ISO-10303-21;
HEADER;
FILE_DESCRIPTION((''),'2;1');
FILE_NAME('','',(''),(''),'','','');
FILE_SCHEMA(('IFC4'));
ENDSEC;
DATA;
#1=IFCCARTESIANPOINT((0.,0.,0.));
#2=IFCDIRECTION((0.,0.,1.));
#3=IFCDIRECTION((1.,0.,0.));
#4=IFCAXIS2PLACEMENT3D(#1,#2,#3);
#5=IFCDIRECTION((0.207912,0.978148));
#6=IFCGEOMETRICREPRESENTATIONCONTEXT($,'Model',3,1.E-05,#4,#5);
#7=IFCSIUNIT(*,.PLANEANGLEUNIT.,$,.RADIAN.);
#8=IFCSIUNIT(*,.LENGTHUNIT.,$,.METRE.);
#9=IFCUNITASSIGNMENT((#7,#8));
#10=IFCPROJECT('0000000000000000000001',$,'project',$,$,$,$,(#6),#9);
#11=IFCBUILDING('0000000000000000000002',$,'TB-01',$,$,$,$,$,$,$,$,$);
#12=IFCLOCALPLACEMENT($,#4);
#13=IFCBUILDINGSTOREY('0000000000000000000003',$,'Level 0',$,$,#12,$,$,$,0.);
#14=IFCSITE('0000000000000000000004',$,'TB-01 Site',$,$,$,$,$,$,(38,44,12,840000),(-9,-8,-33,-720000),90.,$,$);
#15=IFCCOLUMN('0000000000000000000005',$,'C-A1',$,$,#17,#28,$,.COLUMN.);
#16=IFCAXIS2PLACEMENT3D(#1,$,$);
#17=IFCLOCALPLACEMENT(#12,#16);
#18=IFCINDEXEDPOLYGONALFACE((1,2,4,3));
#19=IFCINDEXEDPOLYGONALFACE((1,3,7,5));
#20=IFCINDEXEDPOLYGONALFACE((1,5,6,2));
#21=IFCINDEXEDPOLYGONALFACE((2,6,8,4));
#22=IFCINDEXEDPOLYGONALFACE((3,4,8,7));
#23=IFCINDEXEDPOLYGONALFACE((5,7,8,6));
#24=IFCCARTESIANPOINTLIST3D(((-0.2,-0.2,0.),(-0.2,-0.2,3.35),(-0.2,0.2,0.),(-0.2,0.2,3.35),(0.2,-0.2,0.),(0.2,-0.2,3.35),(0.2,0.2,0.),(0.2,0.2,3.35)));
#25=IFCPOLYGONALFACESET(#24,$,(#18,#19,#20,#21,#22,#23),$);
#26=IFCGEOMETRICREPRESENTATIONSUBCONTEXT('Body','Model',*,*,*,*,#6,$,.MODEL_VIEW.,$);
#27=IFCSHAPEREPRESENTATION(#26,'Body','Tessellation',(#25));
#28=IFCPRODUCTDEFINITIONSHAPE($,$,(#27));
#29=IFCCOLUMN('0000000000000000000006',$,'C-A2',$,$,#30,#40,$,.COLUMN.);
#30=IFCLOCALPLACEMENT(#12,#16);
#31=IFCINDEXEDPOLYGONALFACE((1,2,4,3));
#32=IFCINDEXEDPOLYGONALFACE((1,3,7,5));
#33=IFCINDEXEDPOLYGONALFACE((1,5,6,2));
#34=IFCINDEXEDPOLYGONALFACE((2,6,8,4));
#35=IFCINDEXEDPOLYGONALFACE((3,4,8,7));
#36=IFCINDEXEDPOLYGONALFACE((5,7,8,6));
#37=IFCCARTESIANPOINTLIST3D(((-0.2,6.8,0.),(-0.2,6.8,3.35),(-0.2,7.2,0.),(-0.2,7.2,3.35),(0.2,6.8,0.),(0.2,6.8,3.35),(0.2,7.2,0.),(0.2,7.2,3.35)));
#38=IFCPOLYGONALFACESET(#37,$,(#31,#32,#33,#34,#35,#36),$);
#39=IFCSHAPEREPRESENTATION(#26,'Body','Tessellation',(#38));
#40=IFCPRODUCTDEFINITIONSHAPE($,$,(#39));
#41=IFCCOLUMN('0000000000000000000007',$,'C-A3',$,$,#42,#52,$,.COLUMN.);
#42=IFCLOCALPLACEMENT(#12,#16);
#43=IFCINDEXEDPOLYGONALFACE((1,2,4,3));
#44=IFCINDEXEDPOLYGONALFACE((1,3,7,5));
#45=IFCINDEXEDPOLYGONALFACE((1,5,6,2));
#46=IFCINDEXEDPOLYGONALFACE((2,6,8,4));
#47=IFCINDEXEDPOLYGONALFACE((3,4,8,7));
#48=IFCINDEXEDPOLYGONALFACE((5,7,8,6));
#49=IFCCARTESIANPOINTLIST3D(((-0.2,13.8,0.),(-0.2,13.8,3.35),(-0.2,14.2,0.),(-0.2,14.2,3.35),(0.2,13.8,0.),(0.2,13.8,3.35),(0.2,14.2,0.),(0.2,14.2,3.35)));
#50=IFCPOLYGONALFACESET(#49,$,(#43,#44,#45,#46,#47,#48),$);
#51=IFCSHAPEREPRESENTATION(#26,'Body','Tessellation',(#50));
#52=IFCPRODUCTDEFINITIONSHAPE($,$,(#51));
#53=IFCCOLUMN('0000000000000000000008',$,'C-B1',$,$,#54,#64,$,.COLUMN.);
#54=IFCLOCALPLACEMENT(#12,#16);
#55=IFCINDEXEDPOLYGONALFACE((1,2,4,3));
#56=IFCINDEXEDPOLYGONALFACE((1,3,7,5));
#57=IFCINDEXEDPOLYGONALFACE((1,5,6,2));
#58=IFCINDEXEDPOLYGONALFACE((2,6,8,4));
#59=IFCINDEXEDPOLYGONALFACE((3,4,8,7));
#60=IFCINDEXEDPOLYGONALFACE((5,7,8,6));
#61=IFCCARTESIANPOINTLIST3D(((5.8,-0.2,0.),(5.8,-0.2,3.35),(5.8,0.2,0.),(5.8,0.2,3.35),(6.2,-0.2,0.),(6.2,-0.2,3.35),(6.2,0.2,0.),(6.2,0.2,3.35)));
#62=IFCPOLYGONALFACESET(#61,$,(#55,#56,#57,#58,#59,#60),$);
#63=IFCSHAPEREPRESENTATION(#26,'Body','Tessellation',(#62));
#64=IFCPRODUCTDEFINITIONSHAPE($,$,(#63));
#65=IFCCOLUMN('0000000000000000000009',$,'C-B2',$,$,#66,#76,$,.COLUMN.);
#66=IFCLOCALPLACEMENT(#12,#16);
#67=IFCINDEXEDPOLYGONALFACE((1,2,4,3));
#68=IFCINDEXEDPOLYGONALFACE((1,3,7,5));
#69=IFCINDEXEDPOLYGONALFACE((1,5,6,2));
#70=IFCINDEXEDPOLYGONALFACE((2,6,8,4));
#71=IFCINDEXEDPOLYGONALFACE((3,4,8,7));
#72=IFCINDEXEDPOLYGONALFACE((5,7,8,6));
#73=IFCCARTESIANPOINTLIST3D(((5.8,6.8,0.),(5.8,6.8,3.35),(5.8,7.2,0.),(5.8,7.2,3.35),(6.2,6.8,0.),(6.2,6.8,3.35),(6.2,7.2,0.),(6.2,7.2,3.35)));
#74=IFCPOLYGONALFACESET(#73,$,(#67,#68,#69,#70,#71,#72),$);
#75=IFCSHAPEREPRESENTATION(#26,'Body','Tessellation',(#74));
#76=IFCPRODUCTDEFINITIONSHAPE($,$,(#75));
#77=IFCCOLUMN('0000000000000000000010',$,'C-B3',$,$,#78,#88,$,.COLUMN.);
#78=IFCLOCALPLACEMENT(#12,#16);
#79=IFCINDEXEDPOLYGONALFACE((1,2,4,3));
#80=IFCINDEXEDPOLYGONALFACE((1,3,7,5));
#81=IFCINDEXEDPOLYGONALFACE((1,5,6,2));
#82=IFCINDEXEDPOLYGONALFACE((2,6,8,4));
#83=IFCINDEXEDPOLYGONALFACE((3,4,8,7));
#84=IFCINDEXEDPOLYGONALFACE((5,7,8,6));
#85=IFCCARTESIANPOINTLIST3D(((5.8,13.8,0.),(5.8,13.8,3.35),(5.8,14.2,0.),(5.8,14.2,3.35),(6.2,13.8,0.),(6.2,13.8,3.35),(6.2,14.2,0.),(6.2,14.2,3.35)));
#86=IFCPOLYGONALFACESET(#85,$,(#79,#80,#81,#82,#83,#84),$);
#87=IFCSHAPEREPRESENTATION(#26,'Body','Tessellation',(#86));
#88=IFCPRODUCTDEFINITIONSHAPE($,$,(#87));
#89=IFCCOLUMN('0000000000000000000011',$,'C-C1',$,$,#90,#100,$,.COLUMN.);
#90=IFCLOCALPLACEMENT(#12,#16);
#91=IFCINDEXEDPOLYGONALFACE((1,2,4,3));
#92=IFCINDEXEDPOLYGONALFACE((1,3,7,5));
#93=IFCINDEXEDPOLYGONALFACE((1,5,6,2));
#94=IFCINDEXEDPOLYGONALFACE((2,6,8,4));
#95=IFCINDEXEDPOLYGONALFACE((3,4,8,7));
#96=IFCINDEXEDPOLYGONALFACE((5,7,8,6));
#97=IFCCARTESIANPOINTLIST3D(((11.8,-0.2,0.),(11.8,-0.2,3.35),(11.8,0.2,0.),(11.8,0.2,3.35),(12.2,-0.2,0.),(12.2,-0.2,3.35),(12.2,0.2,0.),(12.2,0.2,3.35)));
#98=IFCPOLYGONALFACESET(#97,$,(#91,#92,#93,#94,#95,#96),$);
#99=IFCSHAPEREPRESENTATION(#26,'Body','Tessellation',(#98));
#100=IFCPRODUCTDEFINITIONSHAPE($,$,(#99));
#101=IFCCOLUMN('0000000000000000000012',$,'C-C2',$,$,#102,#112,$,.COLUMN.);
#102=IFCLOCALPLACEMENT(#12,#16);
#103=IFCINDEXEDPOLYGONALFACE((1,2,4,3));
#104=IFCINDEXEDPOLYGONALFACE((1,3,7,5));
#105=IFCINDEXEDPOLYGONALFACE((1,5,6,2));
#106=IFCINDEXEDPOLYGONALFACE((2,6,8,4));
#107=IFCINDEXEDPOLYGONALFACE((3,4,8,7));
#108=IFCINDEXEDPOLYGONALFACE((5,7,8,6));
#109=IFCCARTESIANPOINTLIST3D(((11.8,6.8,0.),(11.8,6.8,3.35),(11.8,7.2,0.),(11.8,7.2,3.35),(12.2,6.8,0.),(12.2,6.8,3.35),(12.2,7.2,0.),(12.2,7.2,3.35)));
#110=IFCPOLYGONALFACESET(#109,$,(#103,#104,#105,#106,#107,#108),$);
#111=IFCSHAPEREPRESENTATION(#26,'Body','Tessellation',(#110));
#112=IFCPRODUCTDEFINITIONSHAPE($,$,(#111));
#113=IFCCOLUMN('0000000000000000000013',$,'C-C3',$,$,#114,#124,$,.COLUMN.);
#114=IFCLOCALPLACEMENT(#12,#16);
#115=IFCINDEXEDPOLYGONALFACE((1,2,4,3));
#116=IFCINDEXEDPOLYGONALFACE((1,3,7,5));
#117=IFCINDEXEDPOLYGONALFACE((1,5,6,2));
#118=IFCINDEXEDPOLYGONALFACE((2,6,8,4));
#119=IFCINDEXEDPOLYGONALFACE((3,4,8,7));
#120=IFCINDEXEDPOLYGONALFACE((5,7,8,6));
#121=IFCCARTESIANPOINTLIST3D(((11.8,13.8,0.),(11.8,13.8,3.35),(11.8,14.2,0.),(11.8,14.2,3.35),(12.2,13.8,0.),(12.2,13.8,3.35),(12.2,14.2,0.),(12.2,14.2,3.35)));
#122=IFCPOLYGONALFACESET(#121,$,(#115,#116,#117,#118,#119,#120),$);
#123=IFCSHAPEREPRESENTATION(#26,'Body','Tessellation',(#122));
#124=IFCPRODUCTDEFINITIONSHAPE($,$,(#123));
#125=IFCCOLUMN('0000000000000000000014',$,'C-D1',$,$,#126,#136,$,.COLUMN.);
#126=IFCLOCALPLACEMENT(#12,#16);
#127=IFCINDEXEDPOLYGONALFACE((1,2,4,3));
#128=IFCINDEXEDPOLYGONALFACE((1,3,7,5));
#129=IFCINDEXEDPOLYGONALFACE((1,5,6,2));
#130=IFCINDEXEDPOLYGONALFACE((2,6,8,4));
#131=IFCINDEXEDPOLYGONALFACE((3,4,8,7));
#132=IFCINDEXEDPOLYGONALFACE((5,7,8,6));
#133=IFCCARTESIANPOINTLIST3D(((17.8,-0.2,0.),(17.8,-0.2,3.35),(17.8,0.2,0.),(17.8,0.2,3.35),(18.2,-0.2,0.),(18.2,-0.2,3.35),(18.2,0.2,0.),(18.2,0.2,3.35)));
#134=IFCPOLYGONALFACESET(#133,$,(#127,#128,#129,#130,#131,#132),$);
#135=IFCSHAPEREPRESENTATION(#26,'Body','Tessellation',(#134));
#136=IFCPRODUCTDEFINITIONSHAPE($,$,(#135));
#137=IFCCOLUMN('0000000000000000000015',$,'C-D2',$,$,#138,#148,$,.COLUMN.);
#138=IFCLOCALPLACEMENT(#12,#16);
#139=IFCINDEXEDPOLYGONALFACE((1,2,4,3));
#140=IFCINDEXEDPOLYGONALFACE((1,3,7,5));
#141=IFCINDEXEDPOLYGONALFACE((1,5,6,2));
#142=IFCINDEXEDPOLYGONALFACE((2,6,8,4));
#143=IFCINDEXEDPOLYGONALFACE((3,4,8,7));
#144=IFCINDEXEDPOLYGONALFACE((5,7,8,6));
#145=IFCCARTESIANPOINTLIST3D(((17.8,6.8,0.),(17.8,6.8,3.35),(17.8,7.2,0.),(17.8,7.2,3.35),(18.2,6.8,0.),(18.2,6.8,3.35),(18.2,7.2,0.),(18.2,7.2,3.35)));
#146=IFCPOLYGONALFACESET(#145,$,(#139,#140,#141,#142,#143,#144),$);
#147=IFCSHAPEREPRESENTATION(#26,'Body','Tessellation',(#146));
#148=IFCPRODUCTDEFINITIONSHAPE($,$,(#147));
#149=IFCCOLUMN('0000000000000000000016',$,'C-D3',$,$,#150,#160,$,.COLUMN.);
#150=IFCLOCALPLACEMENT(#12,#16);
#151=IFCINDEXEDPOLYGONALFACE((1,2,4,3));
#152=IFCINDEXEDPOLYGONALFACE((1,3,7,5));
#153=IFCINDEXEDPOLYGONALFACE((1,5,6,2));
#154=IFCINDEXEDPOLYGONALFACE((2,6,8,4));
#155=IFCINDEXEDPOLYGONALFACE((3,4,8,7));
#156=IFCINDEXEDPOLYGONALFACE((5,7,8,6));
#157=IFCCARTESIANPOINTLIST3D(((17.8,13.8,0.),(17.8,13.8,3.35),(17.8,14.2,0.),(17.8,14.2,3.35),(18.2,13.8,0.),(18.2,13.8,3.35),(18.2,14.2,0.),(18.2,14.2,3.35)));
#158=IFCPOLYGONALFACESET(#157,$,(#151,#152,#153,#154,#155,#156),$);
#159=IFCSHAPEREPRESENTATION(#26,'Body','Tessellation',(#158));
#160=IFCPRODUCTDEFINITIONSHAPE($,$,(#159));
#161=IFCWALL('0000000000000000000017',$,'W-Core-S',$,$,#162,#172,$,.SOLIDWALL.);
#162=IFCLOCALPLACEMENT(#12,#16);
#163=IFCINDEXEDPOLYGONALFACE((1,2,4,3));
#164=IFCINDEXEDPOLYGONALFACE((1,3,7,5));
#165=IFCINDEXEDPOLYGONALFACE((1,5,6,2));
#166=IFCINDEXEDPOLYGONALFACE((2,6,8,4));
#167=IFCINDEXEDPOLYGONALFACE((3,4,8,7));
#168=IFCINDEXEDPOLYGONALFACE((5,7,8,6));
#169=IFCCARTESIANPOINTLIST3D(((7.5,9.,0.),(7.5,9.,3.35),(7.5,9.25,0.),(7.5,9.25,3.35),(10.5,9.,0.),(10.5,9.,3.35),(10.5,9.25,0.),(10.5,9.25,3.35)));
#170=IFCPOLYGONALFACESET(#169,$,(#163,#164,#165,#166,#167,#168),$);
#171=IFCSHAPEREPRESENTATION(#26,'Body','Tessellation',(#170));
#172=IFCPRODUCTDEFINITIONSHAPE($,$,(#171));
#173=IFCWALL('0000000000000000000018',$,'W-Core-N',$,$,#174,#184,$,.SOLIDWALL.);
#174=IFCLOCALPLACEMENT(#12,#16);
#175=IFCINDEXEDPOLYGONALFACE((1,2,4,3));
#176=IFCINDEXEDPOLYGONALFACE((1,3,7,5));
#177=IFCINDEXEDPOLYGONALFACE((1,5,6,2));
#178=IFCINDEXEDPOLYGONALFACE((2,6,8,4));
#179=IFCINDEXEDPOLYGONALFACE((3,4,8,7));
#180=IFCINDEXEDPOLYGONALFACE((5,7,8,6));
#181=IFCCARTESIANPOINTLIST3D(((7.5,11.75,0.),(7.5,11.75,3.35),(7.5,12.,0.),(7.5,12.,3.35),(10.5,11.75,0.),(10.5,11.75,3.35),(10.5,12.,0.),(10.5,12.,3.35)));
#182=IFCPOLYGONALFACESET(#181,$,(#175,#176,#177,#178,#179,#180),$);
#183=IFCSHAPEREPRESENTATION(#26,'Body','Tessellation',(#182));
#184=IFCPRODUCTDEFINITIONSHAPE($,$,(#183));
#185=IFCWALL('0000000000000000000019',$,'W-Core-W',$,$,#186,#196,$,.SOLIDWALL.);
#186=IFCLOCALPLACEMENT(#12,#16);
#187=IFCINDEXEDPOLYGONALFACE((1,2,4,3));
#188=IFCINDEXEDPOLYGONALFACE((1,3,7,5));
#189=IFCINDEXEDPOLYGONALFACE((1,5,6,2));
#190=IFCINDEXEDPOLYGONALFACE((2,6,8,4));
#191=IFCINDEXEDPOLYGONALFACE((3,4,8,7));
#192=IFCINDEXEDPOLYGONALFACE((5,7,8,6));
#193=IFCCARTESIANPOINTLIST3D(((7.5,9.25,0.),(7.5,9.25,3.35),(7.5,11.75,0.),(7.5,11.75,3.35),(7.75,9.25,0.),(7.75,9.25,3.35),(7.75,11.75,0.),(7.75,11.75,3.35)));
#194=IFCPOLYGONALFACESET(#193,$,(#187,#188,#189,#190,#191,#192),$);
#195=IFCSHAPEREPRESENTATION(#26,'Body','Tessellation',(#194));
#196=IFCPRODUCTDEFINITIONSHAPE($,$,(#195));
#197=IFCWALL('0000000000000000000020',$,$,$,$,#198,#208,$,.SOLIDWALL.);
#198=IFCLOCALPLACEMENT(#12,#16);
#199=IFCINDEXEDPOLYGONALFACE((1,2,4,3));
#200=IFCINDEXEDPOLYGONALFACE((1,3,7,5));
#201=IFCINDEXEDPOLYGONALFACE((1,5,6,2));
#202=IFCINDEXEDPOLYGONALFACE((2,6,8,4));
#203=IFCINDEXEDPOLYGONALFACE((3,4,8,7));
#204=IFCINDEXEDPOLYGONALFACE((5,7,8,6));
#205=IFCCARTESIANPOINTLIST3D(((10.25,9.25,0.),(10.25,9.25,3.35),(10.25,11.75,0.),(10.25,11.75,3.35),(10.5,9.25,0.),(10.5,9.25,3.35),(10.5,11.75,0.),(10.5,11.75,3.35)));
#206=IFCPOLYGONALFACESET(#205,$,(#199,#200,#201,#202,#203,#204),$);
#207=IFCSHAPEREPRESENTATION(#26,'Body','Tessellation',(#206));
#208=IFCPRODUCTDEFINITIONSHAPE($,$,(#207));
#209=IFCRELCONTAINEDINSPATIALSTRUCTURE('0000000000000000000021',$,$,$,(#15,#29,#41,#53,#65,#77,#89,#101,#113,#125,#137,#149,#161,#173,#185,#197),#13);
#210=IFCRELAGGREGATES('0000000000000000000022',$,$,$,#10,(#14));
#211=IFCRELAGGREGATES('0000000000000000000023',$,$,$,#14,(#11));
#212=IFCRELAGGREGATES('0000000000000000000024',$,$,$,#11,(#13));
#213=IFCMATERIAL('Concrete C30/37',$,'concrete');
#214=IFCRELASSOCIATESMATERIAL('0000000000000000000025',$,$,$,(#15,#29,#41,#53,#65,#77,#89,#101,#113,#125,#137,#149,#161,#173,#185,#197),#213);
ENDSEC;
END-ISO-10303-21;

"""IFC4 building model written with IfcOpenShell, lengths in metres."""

from ifc_helpers import new_model, si_unit, direction, frame, origin_with_axes, place, context, subcontext, project, spatial, rectangle, extrude, material, element, save


model = new_model("IFC4")

# Units and contexts
model_context = context("Model", 3, precision=1e-05, world=origin_with_axes(), true_north=direction((0.207912, 0.978148)))
body_context = subcontext(model_context, "Body", "Model", "MODEL_VIEW")
ifc_project = project(units=[si_unit("PLANEANGLEUNIT", "RADIAN"), si_unit("LENGTHUNIT", "METRE")], contexts=[model_context])

# Site, building, storey
site = spatial("IfcSite", under=ifc_project, Name="TB-01 Site", RefLatitude=(38, 44, 12, 840000), RefLongitude=(-9, -8, -33, -720000), RefElevation=90.0)
building = spatial("IfcBuilding", under=site, Name="TB-01")
storey_placement = place(None, origin_with_axes())
storey = spatial("IfcBuildingStorey", under=building, at=storey_placement, Name="Level 0", Elevation=0.0)

# Columns
ifc_material = material(Name="Concrete C30/37", Category="concrete")
column_1_placement = place(storey_placement, origin_with_axes())
element("IfcColumn", 1, at=column_1_placement, inside=storey, material=ifc_material, Name="C-A1", PredefinedType="COLUMN", context=body_context, shape_type="SweptSolid", body=[
    extrude(rectangle(XDim=0.4, YDim=0.4), origin_with_axes(), (0.0, 0.0, 1.0), 3.35),
])
column_2_placement = place(storey_placement, frame((0.0, 7.0, 0.0), z_axis=(0.0, 0.0, 1.0), x_axis=(1.0, 0.0, 0.0)))
element("IfcColumn", 2, at=column_2_placement, inside=storey, material=ifc_material, Name="C-A2", PredefinedType="COLUMN", context=body_context, shape_type="SweptSolid", body=[
    extrude(rectangle(XDim=0.4, YDim=0.4), origin_with_axes(), (0.0, 0.0, 1.0), 3.35),
])
column_3_placement = place(storey_placement, frame((0.0, 14.0, 0.0), z_axis=(0.0, 0.0, 1.0), x_axis=(1.0, 0.0, 0.0)))
element("IfcColumn", 3, at=column_3_placement, inside=storey, material=ifc_material, Name="C-A3", PredefinedType="COLUMN", context=body_context, shape_type="SweptSolid", body=[
    extrude(rectangle(XDim=0.4, YDim=0.4), origin_with_axes(), (0.0, 0.0, 1.0), 3.35),
])
column_4_placement = place(storey_placement, frame((6.0, 0.0, 0.0), z_axis=(0.0, 0.0, 1.0), x_axis=(1.0, 0.0, 0.0)))
element("IfcColumn", 4, at=column_4_placement, inside=storey, material=ifc_material, Name="C-B1", PredefinedType="COLUMN", context=body_context, shape_type="SweptSolid", body=[
    extrude(rectangle(XDim=0.4, YDim=0.4), origin_with_axes(), (0.0, 0.0, 1.0), 3.35),
])
column_5_placement = place(storey_placement, frame((6.0, 7.0, 0.0), z_axis=(0.0, 0.0, 1.0), x_axis=(1.0, 0.0, 0.0)))
element("IfcColumn", 5, at=column_5_placement, inside=storey, material=ifc_material, Name="C-B2", PredefinedType="COLUMN", context=body_context, shape_type="SweptSolid", body=[
    extrude(rectangle(XDim=0.4, YDim=0.4), origin_with_axes(), (0.0, 0.0, 1.0), 3.35),
])
column_6_placement = place(storey_placement, frame((6.0, 14.0, 0.0), z_axis=(0.0, 0.0, 1.0), x_axis=(1.0, 0.0, 0.0)))
element("IfcColumn", 6, at=column_6_placement, inside=storey, material=ifc_material, Name="C-B3", PredefinedType="COLUMN", context=body_context, shape_type="SweptSolid", body=[
    extrude(rectangle(XDim=0.4, YDim=0.4), origin_with_axes(), (0.0, 0.0, 1.0), 3.35),
])
column_7_placement = place(storey_placement, frame((12.0, 0.0, 0.0), z_axis=(0.0, 0.0, 1.0), x_axis=(1.0, 0.0, 0.0)))
element("IfcColumn", 7, at=column_7_placement, inside=storey, material=ifc_material, Name="C-C1", PredefinedType="COLUMN", context=body_context, shape_type="SweptSolid", body=[
    extrude(rectangle(XDim=0.4, YDim=0.4), origin_with_axes(), (0.0, 0.0, 1.0), 3.35),
])
column_8_placement = place(storey_placement, frame((12.0, 7.0, 0.0), z_axis=(0.0, 0.0, 1.0), x_axis=(1.0, 0.0, 0.0)))
element("IfcColumn", 8, at=column_8_placement, inside=storey, material=ifc_material, Name="C-C2", PredefinedType="COLUMN", context=body_context, shape_type="SweptSolid", body=[
    extrude(rectangle(XDim=0.4, YDim=0.4), origin_with_axes(), (0.0, 0.0, 1.0), 3.35),
])
column_9_placement = place(storey_placement, frame((12.0, 14.0, 0.0), z_axis=(0.0, 0.0, 1.0), x_axis=(1.0, 0.0, 0.0)))
element("IfcColumn", 9, at=column_9_placement, inside=storey, material=ifc_material, Name="C-C3", PredefinedType="COLUMN", context=body_context, shape_type="SweptSolid", body=[
    extrude(rectangle(XDim=0.4, YDim=0.4), origin_with_axes(), (0.0, 0.0, 1.0), 3.35),
])
column_10_placement = place(storey_placement, frame((18.0, 0.0, 0.0), z_axis=(0.0, 0.0, 1.0), x_axis=(1.0, 0.0, 0.0)))
element("IfcColumn", 10, at=column_10_placement, inside=storey, material=ifc_material, Name="C-D1", PredefinedType="COLUMN", context=body_context, shape_type="SweptSolid", body=[
    extrude(rectangle(XDim=0.4, YDim=0.4), origin_with_axes(), (0.0, 0.0, 1.0), 3.35),
])
column_11_placement = place(storey_placement, frame((18.0, 7.0, 0.0), z_axis=(0.0, 0.0, 1.0), x_axis=(1.0, 0.0, 0.0)))
element("IfcColumn", 11, at=column_11_placement, inside=storey, material=ifc_material, Name="C-D2", PredefinedType="COLUMN", context=body_context, shape_type="SweptSolid", body=[
    extrude(rectangle(XDim=0.4, YDim=0.4), origin_with_axes(), (0.0, 0.0, 1.0), 3.35),
])
column_12_placement = place(storey_placement, frame((18.0, 14.0, 0.0), z_axis=(0.0, 0.0, 1.0), x_axis=(1.0, 0.0, 0.0)))
element("IfcColumn", 12, at=column_12_placement, inside=storey, material=ifc_material, Name="C-D3", PredefinedType="COLUMN", context=body_context, shape_type="SweptSolid", body=[
    extrude(rectangle(XDim=0.4, YDim=0.4), origin_with_axes(), (0.0, 0.0, 1.0), 3.35),
])

# Walls
for number, where, z_axis, x_axis, name in (
    (13, (9.0, 9.125, 0.0), (0.0, 0.0, 1.0), (1.0, 0.0, 0.0), "W-Core-S"),
    (14, (9.0, 11.875, 0.0), (0.0, 0.0, 1.0), (1.0, 0.0, 0.0), "W-Core-N"),
):
    element("IfcWall", number, at=place(storey_placement, frame(where, z_axis=z_axis, x_axis=x_axis)), inside=storey, material=ifc_material, Name=name, PredefinedType="SOLIDWALL", context=body_context, shape_type="SweptSolid", body=[
        extrude(rectangle(XDim=3.0, YDim=0.25), origin_with_axes(), (0.0, 0.0, 1.0), 3.35),
    ])
wall_1_placement = place(storey_placement, frame((7.625, 10.5, 0.0), z_axis=(0.0, 0.0, 1.0), x_axis=(1.0, 0.0, 0.0)))
element("IfcWall", 15, at=wall_1_placement, inside=storey, material=ifc_material, Name="W-Core-W", PredefinedType="SOLIDWALL", context=body_context, shape_type="SweptSolid", body=[
    extrude(rectangle(XDim=0.25, YDim=2.5), origin_with_axes(), (0.0, 0.0, 1.0), 3.35),
])
wall_2_placement = place(storey_placement, frame((10.375, 10.5, 0.0), z_axis=(0.0, 0.0, 1.0), x_axis=(1.0, 0.0, 0.0)))
element("IfcWall", 16, at=wall_2_placement, inside=storey, material=ifc_material, PredefinedType="SOLIDWALL", context=body_context, shape_type="SweptSolid", body=[
    extrude(rectangle(XDim=0.25, YDim=2.5), origin_with_axes(), (0.0, 0.0, 1.0), 3.35),
])

save(model, "model.ifc")
